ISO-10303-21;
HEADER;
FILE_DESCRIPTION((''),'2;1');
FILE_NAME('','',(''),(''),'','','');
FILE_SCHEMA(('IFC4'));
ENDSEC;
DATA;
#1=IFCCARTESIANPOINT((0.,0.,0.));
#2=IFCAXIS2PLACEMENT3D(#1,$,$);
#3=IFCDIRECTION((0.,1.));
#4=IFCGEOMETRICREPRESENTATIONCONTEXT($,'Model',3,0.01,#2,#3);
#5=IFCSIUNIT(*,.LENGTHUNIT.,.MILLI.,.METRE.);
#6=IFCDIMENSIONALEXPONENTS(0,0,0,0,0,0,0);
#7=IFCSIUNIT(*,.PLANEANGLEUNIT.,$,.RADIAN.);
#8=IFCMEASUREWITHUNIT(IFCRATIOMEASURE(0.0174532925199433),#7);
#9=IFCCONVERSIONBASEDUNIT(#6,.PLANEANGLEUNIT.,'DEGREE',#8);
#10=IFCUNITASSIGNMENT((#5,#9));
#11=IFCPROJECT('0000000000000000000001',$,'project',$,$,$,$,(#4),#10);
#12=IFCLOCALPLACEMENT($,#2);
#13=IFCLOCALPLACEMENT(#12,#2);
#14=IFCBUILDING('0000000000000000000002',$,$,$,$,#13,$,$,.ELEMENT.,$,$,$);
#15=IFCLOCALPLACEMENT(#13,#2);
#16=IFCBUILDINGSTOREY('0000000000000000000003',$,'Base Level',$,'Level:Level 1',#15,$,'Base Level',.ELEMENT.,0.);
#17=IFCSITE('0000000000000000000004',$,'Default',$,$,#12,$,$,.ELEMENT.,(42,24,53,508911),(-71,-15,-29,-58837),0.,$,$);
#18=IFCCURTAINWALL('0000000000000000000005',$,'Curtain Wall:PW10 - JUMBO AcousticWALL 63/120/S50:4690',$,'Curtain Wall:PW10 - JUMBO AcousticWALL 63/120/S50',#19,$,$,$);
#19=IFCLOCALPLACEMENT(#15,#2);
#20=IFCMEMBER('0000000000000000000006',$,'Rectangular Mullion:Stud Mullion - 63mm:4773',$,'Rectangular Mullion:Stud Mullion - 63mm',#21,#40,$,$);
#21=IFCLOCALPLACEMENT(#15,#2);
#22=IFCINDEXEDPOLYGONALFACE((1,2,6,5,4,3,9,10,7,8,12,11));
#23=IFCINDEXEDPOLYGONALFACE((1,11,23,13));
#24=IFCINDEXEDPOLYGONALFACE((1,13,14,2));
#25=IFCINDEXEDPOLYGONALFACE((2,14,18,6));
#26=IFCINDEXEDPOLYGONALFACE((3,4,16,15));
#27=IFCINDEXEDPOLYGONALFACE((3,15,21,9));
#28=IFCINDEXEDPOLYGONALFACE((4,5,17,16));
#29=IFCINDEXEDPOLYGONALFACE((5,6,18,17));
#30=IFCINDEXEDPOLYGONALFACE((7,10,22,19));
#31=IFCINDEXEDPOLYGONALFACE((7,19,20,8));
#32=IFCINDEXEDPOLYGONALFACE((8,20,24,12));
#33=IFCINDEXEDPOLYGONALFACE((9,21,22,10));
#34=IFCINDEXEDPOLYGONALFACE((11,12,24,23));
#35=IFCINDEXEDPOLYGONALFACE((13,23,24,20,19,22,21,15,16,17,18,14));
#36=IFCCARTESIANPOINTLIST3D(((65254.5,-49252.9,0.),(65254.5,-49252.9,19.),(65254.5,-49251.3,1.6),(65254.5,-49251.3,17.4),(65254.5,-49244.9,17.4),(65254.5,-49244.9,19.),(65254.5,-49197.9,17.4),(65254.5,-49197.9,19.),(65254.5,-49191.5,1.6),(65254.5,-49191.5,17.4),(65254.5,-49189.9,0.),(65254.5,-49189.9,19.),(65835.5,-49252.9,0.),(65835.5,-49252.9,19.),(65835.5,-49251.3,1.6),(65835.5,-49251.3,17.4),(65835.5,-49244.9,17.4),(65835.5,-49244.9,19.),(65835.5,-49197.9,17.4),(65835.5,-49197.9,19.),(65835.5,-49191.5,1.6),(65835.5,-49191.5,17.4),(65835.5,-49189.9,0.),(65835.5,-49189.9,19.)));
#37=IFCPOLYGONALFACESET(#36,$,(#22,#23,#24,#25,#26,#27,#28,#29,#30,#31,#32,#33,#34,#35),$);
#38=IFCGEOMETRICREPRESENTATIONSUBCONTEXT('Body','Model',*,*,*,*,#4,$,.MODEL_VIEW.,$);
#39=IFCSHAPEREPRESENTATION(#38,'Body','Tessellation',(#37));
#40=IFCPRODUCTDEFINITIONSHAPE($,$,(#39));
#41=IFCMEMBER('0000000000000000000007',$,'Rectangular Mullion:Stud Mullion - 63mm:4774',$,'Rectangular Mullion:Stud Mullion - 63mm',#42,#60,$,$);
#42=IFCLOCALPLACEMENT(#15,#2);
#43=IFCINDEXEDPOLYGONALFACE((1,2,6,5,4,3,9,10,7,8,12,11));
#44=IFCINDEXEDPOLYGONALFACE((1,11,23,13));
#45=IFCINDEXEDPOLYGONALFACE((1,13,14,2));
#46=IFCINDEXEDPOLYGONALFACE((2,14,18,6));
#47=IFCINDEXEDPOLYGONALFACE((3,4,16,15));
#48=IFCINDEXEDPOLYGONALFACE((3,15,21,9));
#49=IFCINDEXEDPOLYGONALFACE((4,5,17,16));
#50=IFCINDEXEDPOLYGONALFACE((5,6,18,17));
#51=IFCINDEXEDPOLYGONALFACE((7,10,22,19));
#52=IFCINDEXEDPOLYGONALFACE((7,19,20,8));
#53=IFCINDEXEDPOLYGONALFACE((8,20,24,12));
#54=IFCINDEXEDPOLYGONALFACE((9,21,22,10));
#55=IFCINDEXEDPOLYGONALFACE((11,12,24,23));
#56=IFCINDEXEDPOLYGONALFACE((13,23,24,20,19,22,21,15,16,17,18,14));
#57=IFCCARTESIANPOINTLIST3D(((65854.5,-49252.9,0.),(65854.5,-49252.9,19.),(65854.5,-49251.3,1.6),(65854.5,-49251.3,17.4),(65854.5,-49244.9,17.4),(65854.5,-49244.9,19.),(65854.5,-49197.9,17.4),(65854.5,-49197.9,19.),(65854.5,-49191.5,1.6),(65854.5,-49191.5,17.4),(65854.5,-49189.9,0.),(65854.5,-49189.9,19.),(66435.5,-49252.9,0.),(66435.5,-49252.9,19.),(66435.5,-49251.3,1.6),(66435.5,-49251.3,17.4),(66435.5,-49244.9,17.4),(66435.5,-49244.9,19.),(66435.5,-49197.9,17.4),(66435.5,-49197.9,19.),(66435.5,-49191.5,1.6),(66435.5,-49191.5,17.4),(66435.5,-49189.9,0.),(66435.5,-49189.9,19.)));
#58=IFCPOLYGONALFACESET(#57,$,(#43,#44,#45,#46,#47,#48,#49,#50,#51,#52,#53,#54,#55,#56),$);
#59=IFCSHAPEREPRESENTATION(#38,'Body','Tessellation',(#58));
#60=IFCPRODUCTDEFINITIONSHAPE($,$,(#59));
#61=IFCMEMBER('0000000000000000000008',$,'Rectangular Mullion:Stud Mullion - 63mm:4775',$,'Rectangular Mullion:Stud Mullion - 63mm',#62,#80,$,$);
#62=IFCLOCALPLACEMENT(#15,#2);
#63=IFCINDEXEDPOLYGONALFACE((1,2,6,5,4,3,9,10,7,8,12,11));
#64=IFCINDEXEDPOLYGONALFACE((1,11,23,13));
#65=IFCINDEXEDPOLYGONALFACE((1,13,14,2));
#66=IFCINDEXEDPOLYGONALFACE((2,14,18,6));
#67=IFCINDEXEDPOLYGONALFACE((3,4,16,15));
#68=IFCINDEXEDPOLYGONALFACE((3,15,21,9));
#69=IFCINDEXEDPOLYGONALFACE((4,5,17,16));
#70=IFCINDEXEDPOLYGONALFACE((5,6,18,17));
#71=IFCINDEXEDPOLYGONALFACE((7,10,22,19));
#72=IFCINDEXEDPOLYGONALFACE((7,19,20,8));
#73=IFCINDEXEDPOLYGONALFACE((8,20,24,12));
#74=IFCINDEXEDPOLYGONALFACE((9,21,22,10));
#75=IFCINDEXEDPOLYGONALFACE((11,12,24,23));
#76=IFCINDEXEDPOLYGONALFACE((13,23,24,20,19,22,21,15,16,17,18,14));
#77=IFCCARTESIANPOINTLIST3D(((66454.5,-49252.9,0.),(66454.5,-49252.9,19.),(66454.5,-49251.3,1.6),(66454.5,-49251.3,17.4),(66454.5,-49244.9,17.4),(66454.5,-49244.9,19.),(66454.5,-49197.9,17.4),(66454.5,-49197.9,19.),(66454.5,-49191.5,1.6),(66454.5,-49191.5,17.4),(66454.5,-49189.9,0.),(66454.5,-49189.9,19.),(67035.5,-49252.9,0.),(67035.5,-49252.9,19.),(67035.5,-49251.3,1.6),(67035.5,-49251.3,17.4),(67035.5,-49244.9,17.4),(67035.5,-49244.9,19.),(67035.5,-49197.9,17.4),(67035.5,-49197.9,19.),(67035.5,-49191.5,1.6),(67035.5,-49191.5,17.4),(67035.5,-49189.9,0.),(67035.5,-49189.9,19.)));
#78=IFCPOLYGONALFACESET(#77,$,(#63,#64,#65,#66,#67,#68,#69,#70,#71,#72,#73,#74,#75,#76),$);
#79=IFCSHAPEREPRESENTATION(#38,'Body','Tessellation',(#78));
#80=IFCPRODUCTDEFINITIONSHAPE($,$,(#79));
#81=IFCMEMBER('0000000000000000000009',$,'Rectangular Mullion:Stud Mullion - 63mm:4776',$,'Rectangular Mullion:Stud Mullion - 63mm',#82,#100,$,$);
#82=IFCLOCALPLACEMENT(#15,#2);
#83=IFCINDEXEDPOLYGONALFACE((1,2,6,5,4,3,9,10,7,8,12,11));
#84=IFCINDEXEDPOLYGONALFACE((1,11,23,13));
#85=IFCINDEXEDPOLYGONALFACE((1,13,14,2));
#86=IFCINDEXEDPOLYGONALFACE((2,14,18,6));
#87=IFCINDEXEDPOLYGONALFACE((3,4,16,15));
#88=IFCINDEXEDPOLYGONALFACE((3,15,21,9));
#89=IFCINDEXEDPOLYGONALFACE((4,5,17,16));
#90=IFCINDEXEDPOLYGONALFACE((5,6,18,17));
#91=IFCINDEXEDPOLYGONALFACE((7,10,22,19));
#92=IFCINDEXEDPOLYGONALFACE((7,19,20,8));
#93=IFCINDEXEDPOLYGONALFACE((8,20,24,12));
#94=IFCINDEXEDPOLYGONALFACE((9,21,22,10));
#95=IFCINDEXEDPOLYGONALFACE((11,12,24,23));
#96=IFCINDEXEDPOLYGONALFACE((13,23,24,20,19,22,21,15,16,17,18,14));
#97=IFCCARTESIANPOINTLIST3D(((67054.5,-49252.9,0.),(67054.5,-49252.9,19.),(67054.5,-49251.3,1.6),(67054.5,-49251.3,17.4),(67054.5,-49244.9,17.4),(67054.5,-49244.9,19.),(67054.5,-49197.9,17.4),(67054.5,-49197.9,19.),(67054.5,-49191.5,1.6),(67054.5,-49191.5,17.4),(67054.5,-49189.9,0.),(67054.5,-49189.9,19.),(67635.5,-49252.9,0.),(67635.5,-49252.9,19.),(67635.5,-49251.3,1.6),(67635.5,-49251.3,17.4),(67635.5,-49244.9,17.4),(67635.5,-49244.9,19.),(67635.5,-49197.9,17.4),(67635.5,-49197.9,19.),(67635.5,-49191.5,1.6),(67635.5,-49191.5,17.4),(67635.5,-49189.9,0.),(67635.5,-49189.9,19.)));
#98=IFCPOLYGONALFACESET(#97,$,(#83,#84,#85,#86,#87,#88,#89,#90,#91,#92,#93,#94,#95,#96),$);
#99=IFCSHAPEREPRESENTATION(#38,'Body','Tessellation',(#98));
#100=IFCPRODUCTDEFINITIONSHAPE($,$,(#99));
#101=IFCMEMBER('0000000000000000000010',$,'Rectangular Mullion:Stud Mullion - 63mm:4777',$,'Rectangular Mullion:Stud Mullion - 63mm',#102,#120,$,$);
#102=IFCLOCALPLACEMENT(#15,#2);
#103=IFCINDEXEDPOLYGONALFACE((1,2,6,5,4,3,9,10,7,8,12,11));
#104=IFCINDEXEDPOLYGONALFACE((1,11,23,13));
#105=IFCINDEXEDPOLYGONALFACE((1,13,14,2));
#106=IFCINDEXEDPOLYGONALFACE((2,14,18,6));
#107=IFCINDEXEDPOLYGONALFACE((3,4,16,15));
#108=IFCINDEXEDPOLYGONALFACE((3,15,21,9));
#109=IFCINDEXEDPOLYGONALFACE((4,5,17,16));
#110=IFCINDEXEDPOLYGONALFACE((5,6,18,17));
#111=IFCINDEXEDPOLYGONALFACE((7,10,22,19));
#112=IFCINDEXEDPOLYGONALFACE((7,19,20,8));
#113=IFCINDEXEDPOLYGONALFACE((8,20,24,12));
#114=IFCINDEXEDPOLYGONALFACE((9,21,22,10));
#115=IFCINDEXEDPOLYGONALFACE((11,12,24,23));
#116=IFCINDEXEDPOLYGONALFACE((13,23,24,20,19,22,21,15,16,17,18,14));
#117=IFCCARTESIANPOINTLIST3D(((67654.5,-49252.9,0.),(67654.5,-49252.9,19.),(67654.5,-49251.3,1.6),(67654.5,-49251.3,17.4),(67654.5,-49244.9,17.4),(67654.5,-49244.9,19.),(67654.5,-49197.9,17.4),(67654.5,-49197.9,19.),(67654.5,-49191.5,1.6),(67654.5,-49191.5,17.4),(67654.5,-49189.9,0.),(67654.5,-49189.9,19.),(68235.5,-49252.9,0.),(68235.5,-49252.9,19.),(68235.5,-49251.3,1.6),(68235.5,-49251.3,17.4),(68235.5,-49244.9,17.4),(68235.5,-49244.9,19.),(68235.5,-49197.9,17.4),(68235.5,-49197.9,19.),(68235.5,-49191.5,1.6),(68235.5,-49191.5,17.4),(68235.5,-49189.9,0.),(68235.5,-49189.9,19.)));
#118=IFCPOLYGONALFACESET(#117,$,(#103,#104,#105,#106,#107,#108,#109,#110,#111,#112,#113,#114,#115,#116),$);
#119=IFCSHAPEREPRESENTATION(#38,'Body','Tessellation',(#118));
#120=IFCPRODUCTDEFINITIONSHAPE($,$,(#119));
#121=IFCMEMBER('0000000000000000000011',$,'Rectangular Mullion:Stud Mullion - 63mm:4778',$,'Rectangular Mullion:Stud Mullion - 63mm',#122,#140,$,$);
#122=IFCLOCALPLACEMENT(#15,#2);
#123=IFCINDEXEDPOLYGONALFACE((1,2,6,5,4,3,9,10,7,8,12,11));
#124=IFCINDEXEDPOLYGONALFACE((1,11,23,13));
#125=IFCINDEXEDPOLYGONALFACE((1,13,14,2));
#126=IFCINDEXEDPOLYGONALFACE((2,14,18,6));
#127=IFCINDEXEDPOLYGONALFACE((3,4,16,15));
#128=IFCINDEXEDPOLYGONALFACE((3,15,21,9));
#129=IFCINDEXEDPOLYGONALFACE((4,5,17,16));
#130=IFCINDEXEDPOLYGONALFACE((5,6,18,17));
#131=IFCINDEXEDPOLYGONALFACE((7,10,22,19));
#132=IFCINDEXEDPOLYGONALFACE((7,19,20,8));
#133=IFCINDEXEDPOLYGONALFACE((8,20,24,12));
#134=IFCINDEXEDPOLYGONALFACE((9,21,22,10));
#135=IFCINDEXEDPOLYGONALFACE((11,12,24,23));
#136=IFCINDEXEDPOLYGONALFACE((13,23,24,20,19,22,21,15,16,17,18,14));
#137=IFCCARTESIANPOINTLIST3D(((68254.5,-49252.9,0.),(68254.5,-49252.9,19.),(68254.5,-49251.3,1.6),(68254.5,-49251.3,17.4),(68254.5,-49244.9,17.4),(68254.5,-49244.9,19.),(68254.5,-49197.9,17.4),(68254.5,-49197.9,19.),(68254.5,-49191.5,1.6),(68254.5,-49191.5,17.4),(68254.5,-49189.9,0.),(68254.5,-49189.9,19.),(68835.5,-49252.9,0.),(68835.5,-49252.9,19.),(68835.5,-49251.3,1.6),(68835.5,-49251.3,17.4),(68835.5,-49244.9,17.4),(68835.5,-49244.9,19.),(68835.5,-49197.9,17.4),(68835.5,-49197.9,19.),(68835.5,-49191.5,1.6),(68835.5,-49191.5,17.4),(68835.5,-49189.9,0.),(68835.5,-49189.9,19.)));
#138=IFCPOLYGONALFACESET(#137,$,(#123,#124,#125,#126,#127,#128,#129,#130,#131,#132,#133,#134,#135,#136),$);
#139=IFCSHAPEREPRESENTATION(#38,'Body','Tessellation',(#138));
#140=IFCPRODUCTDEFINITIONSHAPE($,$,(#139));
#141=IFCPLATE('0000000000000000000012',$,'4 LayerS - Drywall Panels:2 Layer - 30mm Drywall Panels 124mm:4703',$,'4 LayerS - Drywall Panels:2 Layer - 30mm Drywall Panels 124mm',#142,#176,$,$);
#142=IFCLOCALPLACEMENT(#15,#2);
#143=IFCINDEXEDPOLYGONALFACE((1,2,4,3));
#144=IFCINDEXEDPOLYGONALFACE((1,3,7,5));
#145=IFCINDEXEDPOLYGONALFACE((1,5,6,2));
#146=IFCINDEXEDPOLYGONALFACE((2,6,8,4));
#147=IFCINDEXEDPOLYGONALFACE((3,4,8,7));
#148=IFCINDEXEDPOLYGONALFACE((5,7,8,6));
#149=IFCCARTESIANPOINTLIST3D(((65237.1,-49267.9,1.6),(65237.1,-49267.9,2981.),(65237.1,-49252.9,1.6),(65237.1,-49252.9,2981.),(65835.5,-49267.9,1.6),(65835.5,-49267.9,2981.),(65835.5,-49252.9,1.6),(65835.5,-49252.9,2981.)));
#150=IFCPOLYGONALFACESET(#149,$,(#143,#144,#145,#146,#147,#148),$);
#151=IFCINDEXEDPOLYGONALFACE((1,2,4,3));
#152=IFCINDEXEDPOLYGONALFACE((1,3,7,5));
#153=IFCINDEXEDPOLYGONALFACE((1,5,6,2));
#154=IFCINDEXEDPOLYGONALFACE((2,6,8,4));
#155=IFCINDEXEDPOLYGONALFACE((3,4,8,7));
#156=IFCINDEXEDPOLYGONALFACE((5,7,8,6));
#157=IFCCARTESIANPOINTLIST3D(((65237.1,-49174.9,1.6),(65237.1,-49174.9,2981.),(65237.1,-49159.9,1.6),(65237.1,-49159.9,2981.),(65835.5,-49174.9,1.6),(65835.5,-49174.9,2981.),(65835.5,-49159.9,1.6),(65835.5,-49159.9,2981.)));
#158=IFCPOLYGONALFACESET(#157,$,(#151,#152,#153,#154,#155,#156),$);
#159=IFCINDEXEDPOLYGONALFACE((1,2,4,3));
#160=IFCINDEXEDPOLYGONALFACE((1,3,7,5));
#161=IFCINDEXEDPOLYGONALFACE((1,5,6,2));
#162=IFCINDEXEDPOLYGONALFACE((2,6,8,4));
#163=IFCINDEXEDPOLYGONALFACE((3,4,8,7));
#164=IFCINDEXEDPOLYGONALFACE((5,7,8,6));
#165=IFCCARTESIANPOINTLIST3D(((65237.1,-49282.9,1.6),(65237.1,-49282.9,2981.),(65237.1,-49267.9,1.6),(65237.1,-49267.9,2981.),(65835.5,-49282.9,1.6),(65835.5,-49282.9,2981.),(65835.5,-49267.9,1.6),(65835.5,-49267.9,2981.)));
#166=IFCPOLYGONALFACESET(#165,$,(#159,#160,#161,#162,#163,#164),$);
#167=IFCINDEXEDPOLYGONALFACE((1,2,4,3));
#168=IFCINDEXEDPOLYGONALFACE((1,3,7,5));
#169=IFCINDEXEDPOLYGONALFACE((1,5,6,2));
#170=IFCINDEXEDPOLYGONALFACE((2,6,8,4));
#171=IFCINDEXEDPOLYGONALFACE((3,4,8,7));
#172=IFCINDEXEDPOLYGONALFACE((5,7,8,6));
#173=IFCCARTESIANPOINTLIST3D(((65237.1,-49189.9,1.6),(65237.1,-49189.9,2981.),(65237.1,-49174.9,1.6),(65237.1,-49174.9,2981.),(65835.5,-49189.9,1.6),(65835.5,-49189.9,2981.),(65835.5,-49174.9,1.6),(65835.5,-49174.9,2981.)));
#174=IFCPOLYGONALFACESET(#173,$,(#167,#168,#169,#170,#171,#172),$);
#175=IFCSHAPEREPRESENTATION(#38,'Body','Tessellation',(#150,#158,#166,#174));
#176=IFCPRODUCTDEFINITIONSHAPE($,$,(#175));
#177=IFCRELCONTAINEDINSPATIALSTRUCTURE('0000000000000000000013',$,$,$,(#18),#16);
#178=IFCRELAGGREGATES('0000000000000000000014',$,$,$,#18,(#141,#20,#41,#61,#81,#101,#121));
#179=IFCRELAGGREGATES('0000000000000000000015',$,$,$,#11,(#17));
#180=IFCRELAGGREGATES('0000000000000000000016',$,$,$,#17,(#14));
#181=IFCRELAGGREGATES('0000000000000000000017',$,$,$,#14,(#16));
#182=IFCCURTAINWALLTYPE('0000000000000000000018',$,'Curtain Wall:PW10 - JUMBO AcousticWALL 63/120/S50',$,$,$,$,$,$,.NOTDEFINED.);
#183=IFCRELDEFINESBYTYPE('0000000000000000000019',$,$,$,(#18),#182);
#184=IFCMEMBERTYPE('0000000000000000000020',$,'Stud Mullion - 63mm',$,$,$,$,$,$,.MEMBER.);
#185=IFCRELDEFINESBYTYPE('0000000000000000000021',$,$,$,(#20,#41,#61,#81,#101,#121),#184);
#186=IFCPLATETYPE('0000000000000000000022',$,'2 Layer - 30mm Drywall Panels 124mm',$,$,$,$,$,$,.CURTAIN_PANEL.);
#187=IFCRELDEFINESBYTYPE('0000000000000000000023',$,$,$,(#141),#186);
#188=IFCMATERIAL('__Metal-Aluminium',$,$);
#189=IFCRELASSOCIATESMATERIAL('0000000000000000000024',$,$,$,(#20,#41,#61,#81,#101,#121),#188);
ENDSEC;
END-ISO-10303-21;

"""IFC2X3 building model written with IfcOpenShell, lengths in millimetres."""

from ifc_helpers import new_model, entity, si_unit, converted_unit, direction, frame, frame_2d, origin, origin_2d_with_axis, place, context, subcontext, project, spatial, polyline, rectangle, outline, extrude, source, transform, mapped, material, type_object, type_shapes, element, aggregate, save


model = new_model("IFC2X3")

# Units and contexts
model_context = context("Model", 3, precision=0.01, world=origin(), true_north=direction((0.0, 1.0)))
body_context = subcontext(model_context, "Body", "Model", "MODEL_VIEW")
ifc_project = project(units=[si_unit("LENGTHUNIT", "METRE", prefix="MILLI"), converted_unit("PLANEANGLEUNIT", "DEGREE", entity("IfcRatioMeasure", 0.0174532925199433), si_unit("PLANEANGLEUNIT", "RADIAN"), dimensions=[0, 0, 0, 0, 0, 0, 0])], contexts=[model_context])

# Site, building, storey
site_placement = place(None, origin())
site = spatial("IfcSite", under=ifc_project, at=site_placement, Name="Default", CompositionType="ELEMENT", RefLatitude=(42, 24, 53, 508911), RefLongitude=(-71, -15, -29, -58837), RefElevation=0.0)
building_placement = place(site_placement, origin())
building = spatial("IfcBuilding", under=site, at=building_placement, CompositionType="ELEMENT")
storey_placement = place(building_placement, origin())
storey = spatial("IfcBuildingStorey", under=building, at=storey_placement, Name="Base Level", ObjectType="Level:Level 1", LongName="Base Level", CompositionType="ELEMENT", Elevation=0.0)

# Curtain wall, members, plate
curtain_wall_type = type_object("IfcCurtainWallType", Name="Curtain Wall:PW10 - JUMBO AcousticWALL 63/120/S50", PredefinedType="NOTDEFINED")
curtain_wall_placement = place(building_placement, origin())
curtain_wall = element("IfcCurtainWall", 1, at=curtain_wall_placement, inside=storey, type_object=curtain_wall_type, Name="Curtain Wall:PW10 - JUMBO AcousticWALL 63/120/S50:4690", ObjectType="Curtain Wall:PW10 - JUMBO AcousticWALL 63/120/S50")
ifc_material = material(Name="__Metal-Aluminium")
member_type_1 = type_object("IfcMemberType", Name="Stud Mullion - 63mm", PredefinedType="MEMBER")
shared_shape_1 = source(origin(), body_context, "Body", "SweptSolid", [
    extrude(outline(polyline([(23.5, -6.6), (31.5, -6.6), (31.5, 12.4), (-31.5, 12.4), (-31.5, -6.6), (-23.5, -6.6), (-23.5, -5.0), (-29.9, -5.0), (-29.9, 10.8), (29.9, 10.8), (29.9, -5.0), (23.5, -5.0), (23.5, -6.6)])), frame((-12.4, 0.0, -581.0), z_axis=(0.0, 0.0, 1.0), x_axis=(0.0, -1.0, 0.0)), (0.0, 0.0, 1.0), 581.0),
])
type_shapes(member_type_1, [shared_shape_1])
member_1_placement = place(building_placement, frame((65254.5, -49221.4, 0.0), z_axis=(-1.0, 0.0, 0.0), x_axis=(0.0, 0.0, -1.0)))
member_1 = element("IfcMember", 2, at=member_1_placement, type_object=member_type_1, material=ifc_material, Name="Rectangular Mullion:Stud Mullion - 63mm:4773", ObjectType="Rectangular Mullion:Stud Mullion - 63mm", context=body_context, shape_type="MappedRepresentation", body=[
    mapped(shared_shape_1, transform((0.0, 0.0, 0.0), scale=1.0)),
])
member_2_placement = place(building_placement, frame((65854.5, -49221.4, 0.0), z_axis=(-1.0, 0.0, 0.0), x_axis=(0.0, 0.0, -1.0)))
member_2 = element("IfcMember", 3, at=member_2_placement, type_object=member_type_1, material=ifc_material, Name="Rectangular Mullion:Stud Mullion - 63mm:4774", ObjectType="Rectangular Mullion:Stud Mullion - 63mm", context=body_context, shape_type="MappedRepresentation", body=[
    mapped(shared_shape_1, transform((0.0, 0.0, 0.0), scale=1.0)),
])
member_3_placement = place(building_placement, frame((66454.5, -49221.4, 0.0), z_axis=(-1.0, 0.0, 0.0), x_axis=(0.0, 0.0, -1.0)))
member_3 = element("IfcMember", 4, at=member_3_placement, type_object=member_type_1, material=ifc_material, Name="Rectangular Mullion:Stud Mullion - 63mm:4775", ObjectType="Rectangular Mullion:Stud Mullion - 63mm", context=body_context, shape_type="MappedRepresentation", body=[
    mapped(shared_shape_1, transform((0.0, 0.0, 0.0), scale=1.0)),
])
member_4_placement = place(building_placement, frame((67054.5, -49221.4, 0.0), z_axis=(-1.0, 0.0, 0.0), x_axis=(0.0, 0.0, -1.0)))
member_4 = element("IfcMember", 5, at=member_4_placement, type_object=member_type_1, material=ifc_material, Name="Rectangular Mullion:Stud Mullion - 63mm:4776", ObjectType="Rectangular Mullion:Stud Mullion - 63mm", context=body_context, shape_type="MappedRepresentation", body=[
    mapped(shared_shape_1, transform((0.0, 0.0, 0.0), scale=1.0)),
])
member_5_placement = place(building_placement, frame((67654.5, -49221.4, 0.0), z_axis=(-1.0, 0.0, 0.0), x_axis=(0.0, 0.0, -1.0)))
member_5 = element("IfcMember", 6, at=member_5_placement, type_object=member_type_1, material=ifc_material, Name="Rectangular Mullion:Stud Mullion - 63mm:4777", ObjectType="Rectangular Mullion:Stud Mullion - 63mm", context=body_context, shape_type="MappedRepresentation", body=[
    mapped(shared_shape_1, transform((0.0, 0.0, 0.0), scale=1.0)),
])
member_6_placement = place(building_placement, frame((68254.5, -49221.4, 0.0), z_axis=(-1.0, 0.0, 0.0), x_axis=(0.0, 0.0, -1.0)))
member_6 = element("IfcMember", 7, at=member_6_placement, type_object=member_type_1, material=ifc_material, Name="Rectangular Mullion:Stud Mullion - 63mm:4778", ObjectType="Rectangular Mullion:Stud Mullion - 63mm", context=body_context, shape_type="MappedRepresentation", body=[
    mapped(shared_shape_1, transform((0.0, 0.0, 0.0), scale=1.0)),
])
plate_type = type_object("IfcPlateType", Name="2 Layer - 30mm Drywall Panels 124mm", PredefinedType="CURTAIN_PANEL")
shared_shape_2 = source(origin(), body_context, "Body", "SweptSolid", [
    extrude(rectangle(XDim=15.0, YDim=598.4, at=origin_2d_with_axis()), frame((0.0, -39.0, 0.0), z_axis=(0.0, 0.0, 1.0), x_axis=(0.0, 1.0, 0.0)), (0.0, 0.0, 1.0), 2979.4),
    extrude(rectangle(XDim=15.0, YDim=598.4, at=origin_2d_with_axis()), frame((0.0, 54.0, 0.0), z_axis=(0.0, 0.0, 1.0), x_axis=(0.0, 1.0, 0.0)), (0.0, 0.0, 1.0), 2979.4),
    extrude(rectangle(XDim=598.4, YDim=15.0, at=frame_2d((0.0, 0.0), x_axis=(1.0, 0.0))), frame((0.0, -54.0, 0.0), z_axis=(0.0, 0.0, 1.0), x_axis=(-1.0, 0.0, 0.0)), (0.0, 0.0, 1.0), 2979.4),
    extrude(rectangle(XDim=15.0, YDim=598.4, at=frame_2d((0.0, 0.0), x_axis=(1.0, 0.0))), frame((0.0, 39.0, 0.0), z_axis=(0.0, 0.0, 1.0), x_axis=(0.0, 1.0, 0.0)), (0.0, 0.0, 1.0), 2979.4),
])
type_shapes(plate_type, [shared_shape_2])
plate_1_placement = place(curtain_wall_placement, frame((65536.3, -49221.4, 1.6)))
plate_1 = element("IfcPlate", 8, at=plate_1_placement, type_object=plate_type, Name="4 LayerS - Drywall Panels:2 Layer - 30mm Drywall Panels 124mm:4703", ObjectType="4 LayerS - Drywall Panels:2 Layer - 30mm Drywall Panels 124mm", context=body_context, shape_type="MappedRepresentation", body=[
    mapped(shared_shape_2, transform((0.0, 0.0, 0.0), scale=1.0)),
])
aggregate(curtain_wall, [plate_1, member_1, member_2, member_3, member_4, member_5, member_6])

save(model, "model.ifc")
